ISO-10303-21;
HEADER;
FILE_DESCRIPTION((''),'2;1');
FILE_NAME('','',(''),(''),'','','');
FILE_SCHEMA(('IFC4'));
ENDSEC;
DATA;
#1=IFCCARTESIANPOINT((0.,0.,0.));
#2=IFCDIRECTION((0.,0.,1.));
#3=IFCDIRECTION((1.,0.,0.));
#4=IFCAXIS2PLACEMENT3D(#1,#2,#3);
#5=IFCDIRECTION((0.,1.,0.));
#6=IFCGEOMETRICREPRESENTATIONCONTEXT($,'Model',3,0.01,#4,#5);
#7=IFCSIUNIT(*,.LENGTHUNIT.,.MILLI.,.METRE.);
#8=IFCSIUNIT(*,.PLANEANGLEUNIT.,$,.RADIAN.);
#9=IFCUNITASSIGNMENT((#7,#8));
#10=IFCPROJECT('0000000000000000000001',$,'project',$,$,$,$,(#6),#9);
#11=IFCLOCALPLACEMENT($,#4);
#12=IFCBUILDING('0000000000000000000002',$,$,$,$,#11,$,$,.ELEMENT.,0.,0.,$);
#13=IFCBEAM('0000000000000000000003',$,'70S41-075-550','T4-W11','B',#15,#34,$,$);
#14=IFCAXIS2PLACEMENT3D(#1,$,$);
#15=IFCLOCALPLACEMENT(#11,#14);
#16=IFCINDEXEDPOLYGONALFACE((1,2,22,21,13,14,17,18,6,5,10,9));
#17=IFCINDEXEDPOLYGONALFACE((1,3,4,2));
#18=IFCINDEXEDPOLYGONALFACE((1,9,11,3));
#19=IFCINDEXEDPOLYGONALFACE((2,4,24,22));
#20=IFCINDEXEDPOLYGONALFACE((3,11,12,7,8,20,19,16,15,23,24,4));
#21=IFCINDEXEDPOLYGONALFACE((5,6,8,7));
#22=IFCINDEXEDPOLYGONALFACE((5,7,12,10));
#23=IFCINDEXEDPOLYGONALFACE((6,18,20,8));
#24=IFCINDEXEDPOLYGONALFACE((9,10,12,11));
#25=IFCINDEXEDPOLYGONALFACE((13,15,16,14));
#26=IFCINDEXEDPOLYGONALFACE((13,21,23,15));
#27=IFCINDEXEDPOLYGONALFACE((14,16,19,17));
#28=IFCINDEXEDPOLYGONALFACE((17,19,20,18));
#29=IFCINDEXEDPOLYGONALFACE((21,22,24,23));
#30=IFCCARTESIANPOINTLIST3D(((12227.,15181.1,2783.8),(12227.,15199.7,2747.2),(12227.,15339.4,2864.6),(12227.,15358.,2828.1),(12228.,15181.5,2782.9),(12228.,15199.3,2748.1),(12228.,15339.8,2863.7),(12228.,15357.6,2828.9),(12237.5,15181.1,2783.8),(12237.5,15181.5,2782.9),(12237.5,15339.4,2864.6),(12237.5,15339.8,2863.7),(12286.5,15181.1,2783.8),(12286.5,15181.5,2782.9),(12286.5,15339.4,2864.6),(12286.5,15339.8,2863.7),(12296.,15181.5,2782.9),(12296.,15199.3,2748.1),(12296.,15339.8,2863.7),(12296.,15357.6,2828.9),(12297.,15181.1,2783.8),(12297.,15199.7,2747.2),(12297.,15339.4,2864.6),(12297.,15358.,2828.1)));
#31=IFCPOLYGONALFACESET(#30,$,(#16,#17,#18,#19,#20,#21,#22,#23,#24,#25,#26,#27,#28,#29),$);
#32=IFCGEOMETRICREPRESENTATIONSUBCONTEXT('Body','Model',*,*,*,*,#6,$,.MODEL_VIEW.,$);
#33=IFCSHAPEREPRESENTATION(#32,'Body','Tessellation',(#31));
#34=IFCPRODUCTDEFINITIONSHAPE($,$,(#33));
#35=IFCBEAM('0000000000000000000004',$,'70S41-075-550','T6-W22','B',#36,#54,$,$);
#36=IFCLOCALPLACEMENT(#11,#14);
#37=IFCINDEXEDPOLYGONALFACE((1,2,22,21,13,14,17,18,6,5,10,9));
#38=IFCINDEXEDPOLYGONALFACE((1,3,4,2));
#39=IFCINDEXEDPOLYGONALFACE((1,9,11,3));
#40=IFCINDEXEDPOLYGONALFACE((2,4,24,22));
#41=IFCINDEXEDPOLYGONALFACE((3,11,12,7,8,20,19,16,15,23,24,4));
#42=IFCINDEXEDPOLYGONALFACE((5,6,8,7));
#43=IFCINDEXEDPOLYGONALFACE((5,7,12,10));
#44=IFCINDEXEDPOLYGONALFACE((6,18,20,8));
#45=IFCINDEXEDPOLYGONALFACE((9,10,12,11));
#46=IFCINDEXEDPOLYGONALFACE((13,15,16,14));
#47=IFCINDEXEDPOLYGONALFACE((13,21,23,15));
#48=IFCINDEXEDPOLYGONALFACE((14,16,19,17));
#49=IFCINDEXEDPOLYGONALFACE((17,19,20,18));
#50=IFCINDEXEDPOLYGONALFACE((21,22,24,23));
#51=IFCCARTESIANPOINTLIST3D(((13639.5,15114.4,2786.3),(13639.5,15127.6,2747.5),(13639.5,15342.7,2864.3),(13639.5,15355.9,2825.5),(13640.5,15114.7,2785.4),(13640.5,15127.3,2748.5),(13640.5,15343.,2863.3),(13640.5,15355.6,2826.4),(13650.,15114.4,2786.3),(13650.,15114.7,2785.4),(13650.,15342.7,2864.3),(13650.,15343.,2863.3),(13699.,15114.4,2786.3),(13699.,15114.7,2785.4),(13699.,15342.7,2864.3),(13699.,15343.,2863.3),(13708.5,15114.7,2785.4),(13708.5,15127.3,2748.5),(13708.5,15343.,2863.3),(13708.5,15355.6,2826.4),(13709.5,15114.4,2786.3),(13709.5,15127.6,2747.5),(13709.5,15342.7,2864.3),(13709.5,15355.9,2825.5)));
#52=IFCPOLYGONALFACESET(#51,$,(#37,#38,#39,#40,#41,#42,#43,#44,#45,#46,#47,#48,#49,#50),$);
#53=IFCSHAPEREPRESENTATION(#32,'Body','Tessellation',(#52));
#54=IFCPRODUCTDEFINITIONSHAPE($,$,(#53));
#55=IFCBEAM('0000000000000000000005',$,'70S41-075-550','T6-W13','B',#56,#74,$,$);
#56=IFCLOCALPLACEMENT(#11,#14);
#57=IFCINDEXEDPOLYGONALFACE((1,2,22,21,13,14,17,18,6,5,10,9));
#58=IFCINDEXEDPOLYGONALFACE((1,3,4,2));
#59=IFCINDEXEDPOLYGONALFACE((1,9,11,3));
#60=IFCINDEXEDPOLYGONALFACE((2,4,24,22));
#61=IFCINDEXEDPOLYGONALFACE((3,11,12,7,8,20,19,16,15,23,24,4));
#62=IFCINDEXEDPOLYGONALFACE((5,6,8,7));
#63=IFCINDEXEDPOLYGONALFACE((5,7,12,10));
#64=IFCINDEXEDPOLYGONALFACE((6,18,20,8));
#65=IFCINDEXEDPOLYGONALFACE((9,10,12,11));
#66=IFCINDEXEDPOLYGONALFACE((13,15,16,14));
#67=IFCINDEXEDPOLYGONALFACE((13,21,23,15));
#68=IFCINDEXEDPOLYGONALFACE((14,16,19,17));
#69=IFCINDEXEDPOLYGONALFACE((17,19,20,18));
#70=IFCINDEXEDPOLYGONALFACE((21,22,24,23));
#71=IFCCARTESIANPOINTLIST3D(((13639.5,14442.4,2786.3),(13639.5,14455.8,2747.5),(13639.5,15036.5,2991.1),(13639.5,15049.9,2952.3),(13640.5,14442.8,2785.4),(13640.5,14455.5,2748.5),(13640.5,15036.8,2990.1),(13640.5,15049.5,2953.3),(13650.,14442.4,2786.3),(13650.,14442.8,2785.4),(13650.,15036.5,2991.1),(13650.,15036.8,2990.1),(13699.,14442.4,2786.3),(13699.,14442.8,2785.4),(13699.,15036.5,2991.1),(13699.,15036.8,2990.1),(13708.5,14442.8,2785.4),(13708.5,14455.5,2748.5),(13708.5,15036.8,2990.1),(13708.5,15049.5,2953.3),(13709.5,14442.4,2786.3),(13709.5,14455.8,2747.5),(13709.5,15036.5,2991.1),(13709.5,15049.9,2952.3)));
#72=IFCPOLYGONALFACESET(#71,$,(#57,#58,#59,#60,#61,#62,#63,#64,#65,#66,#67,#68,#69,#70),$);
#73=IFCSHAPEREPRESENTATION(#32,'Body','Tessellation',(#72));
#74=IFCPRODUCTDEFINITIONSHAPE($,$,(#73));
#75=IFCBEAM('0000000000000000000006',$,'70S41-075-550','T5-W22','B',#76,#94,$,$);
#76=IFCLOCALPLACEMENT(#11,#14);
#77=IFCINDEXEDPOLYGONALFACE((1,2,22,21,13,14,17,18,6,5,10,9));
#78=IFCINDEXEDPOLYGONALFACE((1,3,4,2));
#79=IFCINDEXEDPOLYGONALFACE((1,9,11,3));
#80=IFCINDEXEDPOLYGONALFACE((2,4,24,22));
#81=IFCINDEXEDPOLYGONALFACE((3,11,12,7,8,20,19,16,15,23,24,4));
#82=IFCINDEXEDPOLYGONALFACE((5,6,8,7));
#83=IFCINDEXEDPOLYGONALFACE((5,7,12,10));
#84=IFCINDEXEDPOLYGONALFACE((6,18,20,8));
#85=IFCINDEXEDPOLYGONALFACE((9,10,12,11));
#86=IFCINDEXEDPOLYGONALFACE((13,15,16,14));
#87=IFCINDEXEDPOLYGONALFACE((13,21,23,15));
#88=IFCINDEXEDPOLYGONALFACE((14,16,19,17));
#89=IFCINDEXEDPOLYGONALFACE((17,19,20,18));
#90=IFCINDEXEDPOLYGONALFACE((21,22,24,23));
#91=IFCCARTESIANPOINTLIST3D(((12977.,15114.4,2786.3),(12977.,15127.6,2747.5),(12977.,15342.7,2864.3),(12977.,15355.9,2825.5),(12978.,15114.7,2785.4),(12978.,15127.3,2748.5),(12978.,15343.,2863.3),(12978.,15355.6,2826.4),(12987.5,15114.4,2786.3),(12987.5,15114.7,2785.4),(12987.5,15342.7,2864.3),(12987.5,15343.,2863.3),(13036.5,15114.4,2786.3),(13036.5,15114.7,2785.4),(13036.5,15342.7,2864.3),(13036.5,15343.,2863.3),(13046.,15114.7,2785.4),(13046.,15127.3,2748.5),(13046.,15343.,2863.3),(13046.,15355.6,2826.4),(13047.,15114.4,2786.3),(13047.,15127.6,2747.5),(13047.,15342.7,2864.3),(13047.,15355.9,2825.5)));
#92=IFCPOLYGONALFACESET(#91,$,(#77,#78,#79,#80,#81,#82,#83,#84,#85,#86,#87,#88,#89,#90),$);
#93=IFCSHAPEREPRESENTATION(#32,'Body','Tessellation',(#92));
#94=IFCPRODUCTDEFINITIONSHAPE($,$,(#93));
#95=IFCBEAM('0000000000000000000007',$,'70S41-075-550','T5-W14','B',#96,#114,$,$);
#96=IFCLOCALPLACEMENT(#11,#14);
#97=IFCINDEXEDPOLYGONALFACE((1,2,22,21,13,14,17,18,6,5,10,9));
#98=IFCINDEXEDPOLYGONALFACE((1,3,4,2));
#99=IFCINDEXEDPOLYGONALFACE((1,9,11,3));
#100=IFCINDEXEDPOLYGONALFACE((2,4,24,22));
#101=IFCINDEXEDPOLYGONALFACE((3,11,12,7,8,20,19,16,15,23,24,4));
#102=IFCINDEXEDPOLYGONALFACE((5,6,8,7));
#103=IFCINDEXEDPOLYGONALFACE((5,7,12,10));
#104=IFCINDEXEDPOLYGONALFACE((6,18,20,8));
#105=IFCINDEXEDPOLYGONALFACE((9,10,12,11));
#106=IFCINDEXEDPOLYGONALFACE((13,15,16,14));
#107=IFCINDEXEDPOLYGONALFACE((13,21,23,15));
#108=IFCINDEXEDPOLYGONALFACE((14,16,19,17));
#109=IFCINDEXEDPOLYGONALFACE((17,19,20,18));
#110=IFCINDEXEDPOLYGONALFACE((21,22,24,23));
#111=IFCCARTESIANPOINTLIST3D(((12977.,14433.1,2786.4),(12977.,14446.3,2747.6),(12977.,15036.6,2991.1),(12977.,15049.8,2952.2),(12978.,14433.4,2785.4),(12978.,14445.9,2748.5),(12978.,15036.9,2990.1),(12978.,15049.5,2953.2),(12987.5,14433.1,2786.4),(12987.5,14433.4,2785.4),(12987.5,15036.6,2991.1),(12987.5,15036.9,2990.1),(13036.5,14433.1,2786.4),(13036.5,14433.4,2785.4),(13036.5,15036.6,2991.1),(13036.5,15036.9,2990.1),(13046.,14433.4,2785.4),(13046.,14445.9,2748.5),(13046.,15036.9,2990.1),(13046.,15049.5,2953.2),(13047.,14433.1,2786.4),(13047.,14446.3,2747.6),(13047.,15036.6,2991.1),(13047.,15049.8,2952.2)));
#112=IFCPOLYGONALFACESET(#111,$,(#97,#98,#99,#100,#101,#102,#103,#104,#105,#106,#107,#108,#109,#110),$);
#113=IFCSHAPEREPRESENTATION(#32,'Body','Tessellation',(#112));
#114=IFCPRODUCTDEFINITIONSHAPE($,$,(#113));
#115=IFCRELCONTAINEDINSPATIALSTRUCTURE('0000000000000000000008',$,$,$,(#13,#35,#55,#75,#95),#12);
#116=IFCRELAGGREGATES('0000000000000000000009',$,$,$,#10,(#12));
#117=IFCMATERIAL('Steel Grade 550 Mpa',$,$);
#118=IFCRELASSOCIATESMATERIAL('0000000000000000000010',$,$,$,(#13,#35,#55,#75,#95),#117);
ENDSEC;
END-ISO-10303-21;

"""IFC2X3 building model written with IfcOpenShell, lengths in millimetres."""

from ifc_helpers import new_model, si_unit, direction, frame, origin, origin_with_axes, origin_2d_with_axis, place, context, subcontext, project, spatial, c_section, extrude, source, transform, mapped, material, element, save


model = new_model("IFC2X3")

# Units and contexts
model_context = context("Model", 3, precision=0.01, world=origin_with_axes(), true_north=direction((0.0, 1.0, 0.0)))
body_context = subcontext(model_context, "Body", "Model", "MODEL_VIEW")
ifc_project = project(units=[si_unit("LENGTHUNIT", "METRE", prefix="MILLI"), si_unit("PLANEANGLEUNIT", "RADIAN")], contexts=[model_context])

# Building
building_placement = place(None, origin_with_axes())
building = spatial("IfcBuilding", under=ifc_project, at=building_placement, CompositionType="ELEMENT", ElevationOfRefHeight=0.0, ElevationOfTerrain=0.0)

# Shared definitions
ifc_material = material(Name="Steel Grade 550 Mpa")

# Beams
shared_shape_1 = source(origin(), body_context, "Body", "SweptSolid", [
    extrude(c_section(Depth=70.0, Width=41.0, WallThickness=1.0, Girth=10.5, at=origin_2d_with_axis()), origin_with_axes(), (0.0, 0.0, 1.0), 177.7),
])
beam_1_placement = place(None, frame((12262.0, 15190.4, 2765.5), z_axis=(0.0, 0.890651, 0.454688), x_axis=(0.0, -0.454688, 0.890651)))
element("IfcBeam", 1, at=beam_1_placement, inside=building, material=ifc_material, Name="70S41-075-550", Description="T4-W11", ObjectType="B", context=body_context, shape_type="MappedRepresentation", body=[
    mapped(shared_shape_1, transform((0.0, 0.0, 0.0), scale=1.0)),
])
shared_shape_2 = source(origin(), body_context, "Body", "SweptSolid", [
    extrude(c_section(Depth=70.0, Width=41.0, WallThickness=1.0, Girth=10.5, at=origin_2d_with_axis()), origin_with_axes(), (0.0, 0.0, 1.0), 241.3),
])
beam_2_placement = place(None, frame((13674.5, 15121.0, 2766.9), z_axis=(-0.000003, 0.946412, 0.322961), x_axis=(0.000001, -0.322961, 0.946412)))
element("IfcBeam", 2, at=beam_2_placement, inside=building, material=ifc_material, Name="70S41-075-550", Description="T6-W22", ObjectType="B", context=body_context, shape_type="MappedRepresentation", body=[
    mapped(shared_shape_2, transform((0.0, 0.0, 0.0), scale=1.0)),
])
shared_shape_3 = source(origin(), body_context, "Body", "SweptSolid", [
    extrude(c_section(Depth=70.0, Width=41.0, WallThickness=1.0, Girth=10.5, at=origin_2d_with_axis()), origin_with_axes(), (0.0, 0.0, 1.0), 628.4),
])
beam_3_placement = place(None, frame((13674.5, 14449.1, 2766.9), z_axis=(-0.000003, 0.945408, 0.325889), x_axis=(0.000001, -0.325889, 0.945408)))
element("IfcBeam", 3, at=beam_3_placement, inside=building, material=ifc_material, Name="70S41-075-550", Description="T6-W13", ObjectType="B", context=body_context, shape_type="MappedRepresentation", body=[
    mapped(shared_shape_3, transform((0.0, 0.0, 0.0), scale=1.0)),
])
shared_shape_4 = source(origin(), body_context, "Body", "SweptSolid", [
    extrude(c_section(Depth=70.0, Width=41.0, WallThickness=1.0, Girth=10.5, at=origin_2d_with_axis()), origin_with_axes(), (0.0, 0.0, 1.0), 241.3),
])
beam_4_placement = place(None, frame((13012.0, 15121.0, 2766.9), z_axis=(-0.000003, 0.946412, 0.322961), x_axis=(0.000001, -0.322961, 0.946412)))
element("IfcBeam", 4, at=beam_4_placement, inside=building, material=ifc_material, Name="70S41-075-550", Description="T5-W22", ObjectType="B", context=body_context, shape_type="MappedRepresentation", body=[
    mapped(shared_shape_4, transform((0.0, 0.0, 0.0), scale=1.0)),
])
shared_shape_5 = source(origin(), body_context, "Body", "SweptSolid", [
    extrude(c_section(Depth=70.0, Width=41.0, WallThickness=1.0, Girth=10.5, at=origin_2d_with_axis()), origin_with_axes(), (0.0, 0.0, 1.0), 637.3),
])
beam_5_placement = place(None, frame((13012.0, 14439.7, 2767.0), z_axis=(-0.000003, 0.947022, 0.32117), x_axis=(0.000001, -0.32117, 0.947022)))
element("IfcBeam", 5, at=beam_5_placement, inside=building, material=ifc_material, Name="70S41-075-550", Description="T5-W14", ObjectType="B", context=body_context, shape_type="MappedRepresentation", body=[
    mapped(shared_shape_5, transform((0.0, 0.0, 0.0), scale=1.0)),
])

save(model, "model.ifc")
